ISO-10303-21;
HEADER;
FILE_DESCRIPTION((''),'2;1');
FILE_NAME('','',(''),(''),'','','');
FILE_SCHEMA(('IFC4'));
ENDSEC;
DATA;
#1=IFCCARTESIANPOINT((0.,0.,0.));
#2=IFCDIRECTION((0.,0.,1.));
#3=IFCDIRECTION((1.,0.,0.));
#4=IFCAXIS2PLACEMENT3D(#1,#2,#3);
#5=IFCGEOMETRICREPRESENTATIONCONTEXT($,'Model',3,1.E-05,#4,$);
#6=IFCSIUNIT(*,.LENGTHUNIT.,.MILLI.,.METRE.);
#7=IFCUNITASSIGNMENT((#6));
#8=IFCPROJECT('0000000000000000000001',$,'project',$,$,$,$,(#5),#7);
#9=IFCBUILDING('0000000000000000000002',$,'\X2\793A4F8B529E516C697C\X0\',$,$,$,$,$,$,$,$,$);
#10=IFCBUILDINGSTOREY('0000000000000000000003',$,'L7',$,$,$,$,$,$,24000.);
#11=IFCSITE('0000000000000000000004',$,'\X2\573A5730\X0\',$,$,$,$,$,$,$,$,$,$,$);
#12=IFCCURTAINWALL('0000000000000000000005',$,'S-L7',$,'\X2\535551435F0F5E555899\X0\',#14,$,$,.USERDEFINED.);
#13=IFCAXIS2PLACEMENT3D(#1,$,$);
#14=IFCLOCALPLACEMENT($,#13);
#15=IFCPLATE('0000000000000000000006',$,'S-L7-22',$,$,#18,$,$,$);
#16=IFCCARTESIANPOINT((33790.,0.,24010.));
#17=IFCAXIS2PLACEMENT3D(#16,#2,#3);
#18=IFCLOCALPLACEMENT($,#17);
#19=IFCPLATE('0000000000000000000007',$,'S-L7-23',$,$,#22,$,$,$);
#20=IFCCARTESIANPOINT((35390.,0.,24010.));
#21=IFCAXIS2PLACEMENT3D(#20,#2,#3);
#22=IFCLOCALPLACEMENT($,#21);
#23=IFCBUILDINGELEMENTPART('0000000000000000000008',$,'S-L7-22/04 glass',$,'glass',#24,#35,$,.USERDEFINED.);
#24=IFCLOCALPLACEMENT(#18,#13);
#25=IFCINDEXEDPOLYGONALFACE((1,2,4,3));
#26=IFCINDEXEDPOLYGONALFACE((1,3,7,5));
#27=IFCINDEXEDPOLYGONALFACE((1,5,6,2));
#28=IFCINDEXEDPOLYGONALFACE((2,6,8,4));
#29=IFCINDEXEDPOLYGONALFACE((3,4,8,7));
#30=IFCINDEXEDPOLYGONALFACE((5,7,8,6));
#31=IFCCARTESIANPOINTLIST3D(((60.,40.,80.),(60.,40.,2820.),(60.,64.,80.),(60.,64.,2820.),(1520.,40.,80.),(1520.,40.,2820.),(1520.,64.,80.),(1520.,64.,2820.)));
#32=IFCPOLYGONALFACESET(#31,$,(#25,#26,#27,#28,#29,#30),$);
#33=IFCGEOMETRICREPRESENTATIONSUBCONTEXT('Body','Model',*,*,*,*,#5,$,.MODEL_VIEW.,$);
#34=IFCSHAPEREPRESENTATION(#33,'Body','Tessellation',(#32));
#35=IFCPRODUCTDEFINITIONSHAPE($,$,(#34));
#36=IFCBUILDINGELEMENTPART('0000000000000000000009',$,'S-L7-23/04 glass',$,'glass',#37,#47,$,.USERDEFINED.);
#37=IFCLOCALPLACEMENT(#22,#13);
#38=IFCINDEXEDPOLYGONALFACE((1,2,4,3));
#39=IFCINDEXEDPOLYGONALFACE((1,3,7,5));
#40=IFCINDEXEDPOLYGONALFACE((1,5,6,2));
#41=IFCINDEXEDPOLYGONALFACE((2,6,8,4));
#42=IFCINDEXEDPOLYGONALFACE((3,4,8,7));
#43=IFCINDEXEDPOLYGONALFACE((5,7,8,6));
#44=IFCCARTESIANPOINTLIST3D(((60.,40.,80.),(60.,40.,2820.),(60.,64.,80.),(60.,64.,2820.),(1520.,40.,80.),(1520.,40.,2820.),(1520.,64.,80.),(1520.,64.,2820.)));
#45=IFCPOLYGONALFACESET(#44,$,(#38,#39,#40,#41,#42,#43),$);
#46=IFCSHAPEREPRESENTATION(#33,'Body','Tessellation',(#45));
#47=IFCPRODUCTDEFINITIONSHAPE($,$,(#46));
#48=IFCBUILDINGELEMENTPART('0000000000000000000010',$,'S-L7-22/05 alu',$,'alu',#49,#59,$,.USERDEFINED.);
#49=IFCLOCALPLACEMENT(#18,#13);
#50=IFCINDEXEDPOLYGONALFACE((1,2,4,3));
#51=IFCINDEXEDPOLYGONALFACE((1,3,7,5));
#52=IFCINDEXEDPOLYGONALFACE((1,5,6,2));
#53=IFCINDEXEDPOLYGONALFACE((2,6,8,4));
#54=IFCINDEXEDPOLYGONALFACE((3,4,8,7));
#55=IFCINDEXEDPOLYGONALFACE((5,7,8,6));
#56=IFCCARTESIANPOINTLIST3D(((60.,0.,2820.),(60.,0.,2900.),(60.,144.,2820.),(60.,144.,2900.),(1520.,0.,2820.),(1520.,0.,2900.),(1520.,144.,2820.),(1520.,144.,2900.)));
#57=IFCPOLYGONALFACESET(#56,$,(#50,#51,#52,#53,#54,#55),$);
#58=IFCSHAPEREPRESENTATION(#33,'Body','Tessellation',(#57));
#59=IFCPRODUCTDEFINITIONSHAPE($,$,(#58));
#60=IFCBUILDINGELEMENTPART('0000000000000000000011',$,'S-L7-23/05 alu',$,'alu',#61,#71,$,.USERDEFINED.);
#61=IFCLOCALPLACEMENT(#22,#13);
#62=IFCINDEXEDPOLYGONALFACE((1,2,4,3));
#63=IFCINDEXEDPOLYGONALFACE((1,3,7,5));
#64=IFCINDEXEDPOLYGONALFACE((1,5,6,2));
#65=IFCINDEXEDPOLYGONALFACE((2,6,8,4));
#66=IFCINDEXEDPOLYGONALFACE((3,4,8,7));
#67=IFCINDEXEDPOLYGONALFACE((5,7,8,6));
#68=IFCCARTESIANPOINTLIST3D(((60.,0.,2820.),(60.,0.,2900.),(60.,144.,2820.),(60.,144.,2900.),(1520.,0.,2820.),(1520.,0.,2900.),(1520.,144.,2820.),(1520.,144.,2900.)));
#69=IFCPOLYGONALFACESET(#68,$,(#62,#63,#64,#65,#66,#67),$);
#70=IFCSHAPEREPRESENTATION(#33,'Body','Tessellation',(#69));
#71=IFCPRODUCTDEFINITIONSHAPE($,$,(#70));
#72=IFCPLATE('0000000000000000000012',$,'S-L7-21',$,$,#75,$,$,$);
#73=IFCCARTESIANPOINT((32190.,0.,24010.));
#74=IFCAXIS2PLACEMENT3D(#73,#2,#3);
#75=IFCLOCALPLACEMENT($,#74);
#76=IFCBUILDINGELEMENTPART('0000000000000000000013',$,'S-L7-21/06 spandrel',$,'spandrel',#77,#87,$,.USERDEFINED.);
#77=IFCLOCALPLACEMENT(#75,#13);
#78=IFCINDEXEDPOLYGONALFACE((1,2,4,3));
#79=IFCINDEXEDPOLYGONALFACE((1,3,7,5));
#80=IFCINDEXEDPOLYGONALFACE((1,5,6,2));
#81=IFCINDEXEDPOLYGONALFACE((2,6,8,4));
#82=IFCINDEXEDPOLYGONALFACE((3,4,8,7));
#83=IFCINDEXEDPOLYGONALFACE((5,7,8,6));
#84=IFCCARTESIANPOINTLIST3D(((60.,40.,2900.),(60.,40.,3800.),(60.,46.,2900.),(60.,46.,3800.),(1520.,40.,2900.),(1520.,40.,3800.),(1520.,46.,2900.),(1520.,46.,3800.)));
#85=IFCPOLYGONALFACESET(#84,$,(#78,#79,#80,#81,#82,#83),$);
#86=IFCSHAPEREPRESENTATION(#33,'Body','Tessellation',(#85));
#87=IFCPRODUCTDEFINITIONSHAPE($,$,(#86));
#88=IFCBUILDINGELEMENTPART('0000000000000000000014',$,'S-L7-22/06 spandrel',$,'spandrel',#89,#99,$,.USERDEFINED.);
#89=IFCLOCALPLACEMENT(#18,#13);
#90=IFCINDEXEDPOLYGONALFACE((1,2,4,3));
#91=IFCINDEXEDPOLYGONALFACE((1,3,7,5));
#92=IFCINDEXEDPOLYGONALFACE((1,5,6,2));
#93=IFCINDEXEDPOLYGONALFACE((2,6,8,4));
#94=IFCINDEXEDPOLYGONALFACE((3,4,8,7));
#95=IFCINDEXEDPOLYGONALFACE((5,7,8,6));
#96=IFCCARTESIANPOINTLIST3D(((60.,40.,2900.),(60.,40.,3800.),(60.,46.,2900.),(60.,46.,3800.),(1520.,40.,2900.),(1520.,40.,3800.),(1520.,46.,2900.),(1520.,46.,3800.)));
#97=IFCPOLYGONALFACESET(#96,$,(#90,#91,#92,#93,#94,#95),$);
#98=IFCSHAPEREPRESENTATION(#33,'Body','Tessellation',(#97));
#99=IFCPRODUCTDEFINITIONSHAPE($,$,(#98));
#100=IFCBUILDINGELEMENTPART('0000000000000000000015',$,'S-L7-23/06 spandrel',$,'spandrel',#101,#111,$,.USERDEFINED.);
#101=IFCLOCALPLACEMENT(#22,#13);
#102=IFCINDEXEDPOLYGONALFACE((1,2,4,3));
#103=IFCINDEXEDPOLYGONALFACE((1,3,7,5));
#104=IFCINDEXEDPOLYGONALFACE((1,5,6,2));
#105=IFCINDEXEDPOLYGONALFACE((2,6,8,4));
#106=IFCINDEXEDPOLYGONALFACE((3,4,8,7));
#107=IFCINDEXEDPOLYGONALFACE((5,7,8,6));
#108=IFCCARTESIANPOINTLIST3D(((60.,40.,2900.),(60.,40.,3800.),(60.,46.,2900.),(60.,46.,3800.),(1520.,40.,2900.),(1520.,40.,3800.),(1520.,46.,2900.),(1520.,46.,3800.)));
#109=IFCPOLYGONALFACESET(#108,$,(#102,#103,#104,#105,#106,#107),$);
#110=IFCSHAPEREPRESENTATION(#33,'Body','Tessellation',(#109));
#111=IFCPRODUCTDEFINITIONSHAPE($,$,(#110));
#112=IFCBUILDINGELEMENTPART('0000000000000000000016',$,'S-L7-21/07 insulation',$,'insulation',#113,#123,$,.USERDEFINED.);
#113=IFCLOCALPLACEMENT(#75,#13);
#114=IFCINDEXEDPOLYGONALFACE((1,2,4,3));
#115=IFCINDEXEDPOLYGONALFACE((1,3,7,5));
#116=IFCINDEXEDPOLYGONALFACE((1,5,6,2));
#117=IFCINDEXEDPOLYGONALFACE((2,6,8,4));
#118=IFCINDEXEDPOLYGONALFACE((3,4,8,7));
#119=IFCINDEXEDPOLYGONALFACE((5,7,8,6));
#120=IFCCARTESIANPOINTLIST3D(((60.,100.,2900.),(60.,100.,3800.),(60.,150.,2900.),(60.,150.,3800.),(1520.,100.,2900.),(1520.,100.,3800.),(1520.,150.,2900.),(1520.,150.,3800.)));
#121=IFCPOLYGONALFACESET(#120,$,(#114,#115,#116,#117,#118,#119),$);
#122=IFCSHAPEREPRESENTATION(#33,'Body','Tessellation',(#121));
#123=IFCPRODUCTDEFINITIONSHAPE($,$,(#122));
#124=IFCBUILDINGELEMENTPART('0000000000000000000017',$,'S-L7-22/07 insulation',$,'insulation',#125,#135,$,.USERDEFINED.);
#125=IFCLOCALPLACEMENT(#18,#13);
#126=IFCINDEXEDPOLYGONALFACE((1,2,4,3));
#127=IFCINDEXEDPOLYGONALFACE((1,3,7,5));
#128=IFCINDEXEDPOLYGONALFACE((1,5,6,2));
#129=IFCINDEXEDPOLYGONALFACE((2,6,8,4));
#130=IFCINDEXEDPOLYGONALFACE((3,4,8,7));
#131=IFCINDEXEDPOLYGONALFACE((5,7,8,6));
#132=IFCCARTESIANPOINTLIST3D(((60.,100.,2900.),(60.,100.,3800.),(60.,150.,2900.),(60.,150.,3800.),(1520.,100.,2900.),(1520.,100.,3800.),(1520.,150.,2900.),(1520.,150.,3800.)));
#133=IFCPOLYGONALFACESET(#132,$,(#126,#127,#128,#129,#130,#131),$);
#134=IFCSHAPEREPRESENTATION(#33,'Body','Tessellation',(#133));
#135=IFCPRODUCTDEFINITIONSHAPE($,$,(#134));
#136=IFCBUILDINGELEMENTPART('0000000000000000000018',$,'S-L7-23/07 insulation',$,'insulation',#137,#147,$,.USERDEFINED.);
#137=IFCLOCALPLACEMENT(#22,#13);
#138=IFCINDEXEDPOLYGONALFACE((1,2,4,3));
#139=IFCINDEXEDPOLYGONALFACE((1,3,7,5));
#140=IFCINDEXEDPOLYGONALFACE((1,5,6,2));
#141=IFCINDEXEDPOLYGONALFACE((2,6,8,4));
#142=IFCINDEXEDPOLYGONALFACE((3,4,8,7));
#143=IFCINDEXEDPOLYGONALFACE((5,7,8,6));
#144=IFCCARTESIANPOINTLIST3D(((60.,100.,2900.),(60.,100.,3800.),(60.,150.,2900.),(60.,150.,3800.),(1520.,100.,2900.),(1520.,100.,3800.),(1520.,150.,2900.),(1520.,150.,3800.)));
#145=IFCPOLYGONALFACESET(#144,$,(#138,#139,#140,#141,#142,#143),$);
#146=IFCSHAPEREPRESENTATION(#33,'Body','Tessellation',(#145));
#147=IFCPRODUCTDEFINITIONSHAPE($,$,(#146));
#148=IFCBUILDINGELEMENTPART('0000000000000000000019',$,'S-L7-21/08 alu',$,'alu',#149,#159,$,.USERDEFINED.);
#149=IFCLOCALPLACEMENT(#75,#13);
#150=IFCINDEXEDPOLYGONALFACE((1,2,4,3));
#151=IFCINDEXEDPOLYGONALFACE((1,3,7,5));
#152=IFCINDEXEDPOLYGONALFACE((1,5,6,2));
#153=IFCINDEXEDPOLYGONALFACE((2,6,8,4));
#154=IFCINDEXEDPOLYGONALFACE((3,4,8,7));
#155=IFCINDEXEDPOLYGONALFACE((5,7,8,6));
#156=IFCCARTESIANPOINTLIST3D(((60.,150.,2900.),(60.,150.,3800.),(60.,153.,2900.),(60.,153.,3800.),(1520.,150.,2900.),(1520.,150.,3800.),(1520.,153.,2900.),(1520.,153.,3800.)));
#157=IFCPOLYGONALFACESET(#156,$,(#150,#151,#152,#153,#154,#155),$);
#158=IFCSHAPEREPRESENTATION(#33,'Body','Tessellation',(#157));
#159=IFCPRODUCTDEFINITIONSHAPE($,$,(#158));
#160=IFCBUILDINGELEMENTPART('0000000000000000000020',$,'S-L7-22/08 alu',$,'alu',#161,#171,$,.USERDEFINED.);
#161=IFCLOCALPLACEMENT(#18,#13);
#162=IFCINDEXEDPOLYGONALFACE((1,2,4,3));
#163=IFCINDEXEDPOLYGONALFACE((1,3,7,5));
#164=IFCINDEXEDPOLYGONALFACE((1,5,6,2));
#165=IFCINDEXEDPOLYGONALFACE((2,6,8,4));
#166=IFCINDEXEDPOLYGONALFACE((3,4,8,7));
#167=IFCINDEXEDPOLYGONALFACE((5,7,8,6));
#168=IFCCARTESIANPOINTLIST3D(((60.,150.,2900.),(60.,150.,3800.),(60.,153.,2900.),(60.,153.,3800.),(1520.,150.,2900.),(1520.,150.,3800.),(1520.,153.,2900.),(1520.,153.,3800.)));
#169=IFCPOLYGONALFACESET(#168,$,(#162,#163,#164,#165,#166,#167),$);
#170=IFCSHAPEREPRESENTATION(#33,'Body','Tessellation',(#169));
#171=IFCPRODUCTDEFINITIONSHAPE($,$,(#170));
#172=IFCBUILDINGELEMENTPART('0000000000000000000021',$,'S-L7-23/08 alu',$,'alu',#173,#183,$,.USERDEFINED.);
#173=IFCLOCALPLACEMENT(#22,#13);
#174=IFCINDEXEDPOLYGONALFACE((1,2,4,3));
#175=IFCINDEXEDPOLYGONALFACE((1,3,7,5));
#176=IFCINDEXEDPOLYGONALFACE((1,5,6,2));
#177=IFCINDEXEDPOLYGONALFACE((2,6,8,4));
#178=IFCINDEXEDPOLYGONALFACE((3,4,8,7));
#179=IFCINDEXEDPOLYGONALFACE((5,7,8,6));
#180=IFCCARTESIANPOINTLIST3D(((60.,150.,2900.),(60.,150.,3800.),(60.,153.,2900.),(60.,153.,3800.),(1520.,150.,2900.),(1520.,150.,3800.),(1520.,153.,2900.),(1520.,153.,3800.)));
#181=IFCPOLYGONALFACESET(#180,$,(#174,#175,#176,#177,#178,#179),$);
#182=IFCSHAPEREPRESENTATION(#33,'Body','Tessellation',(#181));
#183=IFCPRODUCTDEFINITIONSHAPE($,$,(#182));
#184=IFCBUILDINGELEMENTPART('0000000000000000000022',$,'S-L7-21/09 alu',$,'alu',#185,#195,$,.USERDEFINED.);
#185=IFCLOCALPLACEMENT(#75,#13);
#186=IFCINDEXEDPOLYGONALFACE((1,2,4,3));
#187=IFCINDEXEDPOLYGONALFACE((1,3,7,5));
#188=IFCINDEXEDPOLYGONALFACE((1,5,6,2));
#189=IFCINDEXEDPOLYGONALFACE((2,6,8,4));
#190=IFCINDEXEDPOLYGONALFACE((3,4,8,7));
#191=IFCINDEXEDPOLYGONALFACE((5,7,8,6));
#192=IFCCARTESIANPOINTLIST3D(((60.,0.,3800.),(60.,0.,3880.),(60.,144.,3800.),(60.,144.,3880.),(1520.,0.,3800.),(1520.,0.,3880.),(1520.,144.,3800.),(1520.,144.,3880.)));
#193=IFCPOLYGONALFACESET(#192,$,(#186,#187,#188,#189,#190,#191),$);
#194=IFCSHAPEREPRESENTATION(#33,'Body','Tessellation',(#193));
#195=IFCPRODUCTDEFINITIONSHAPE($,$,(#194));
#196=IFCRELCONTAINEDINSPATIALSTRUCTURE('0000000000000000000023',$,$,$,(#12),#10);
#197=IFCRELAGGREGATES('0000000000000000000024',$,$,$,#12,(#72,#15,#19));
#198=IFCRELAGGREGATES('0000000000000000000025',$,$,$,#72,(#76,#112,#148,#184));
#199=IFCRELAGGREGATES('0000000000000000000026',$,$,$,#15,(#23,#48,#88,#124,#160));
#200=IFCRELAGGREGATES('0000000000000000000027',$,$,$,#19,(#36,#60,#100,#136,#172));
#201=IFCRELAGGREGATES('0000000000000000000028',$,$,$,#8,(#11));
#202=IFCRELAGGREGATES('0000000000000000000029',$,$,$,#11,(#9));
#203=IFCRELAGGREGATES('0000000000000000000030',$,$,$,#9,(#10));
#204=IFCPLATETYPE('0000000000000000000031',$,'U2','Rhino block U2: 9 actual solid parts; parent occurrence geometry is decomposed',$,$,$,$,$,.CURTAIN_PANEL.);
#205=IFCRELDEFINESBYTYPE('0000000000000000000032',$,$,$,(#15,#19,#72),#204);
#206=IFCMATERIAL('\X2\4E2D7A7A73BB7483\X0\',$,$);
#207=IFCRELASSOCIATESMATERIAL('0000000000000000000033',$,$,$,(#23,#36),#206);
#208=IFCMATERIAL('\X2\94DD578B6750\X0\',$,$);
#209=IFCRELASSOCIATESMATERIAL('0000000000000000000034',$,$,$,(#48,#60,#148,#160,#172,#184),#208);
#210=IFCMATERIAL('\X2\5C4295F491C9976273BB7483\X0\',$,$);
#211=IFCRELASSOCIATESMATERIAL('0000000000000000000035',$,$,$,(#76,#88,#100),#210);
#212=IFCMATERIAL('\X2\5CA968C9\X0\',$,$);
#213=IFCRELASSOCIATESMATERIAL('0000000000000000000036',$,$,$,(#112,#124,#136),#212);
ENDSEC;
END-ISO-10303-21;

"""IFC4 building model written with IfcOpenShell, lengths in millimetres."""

from ifc_helpers import new_model, si_unit, frame, frame_2d, origin, origin_with_axes, place, context, subcontext, project, spatial, rectangle, extrude, source, transform, mapped, material, type_object, element, aggregate, save


model = new_model("IFC4")

# Units and contexts
model_context = context("Model", 3, precision=1e-05, world=origin_with_axes())
body_context = subcontext(model_context, "Body", "Model", "MODEL_VIEW")
ifc_project = project(units=[si_unit("LENGTHUNIT", "METRE", prefix="MILLI")], contexts=[model_context])

# Site, building, storey
site = spatial("IfcSite", under=ifc_project, Name="场地")
building = spatial("IfcBuilding", under=site, Name="示例办公楼")
storey = spatial("IfcBuildingStorey", under=building, Name="L7", Elevation=24000.0)

# Curtain wall, plates, building element parts
curtain_wall = element("IfcCurtainWall", 1, inside=storey, Name="S-L7", ObjectType="单元式幕墙", PredefinedType="USERDEFINED")
plate_type = type_object("IfcPlateType", Name="U2", Description="Rhino block U2: 9 actual solid parts; parent occurrence geometry is decomposed", PredefinedType="CURTAIN_PANEL")
plate_1_placement = place(None, frame((33790.0, 0.0, 24010.0), z_axis=(0.0, 0.0, 1.0), x_axis=(1.0, 0.0, 0.0)))
plate_1 = element("IfcPlate", 2, at=plate_1_placement, type_object=plate_type, Name="S-L7-22")
ifc_material_1 = material(Name="铝型材")
plate_2_placement = place(None, frame((35390.0, 0.0, 24010.0), z_axis=(0.0, 0.0, 1.0), x_axis=(1.0, 0.0, 0.0)))
plate_2 = element("IfcPlate", 3, at=plate_2_placement, type_object=plate_type, Name="S-L7-23")
ifc_material_2 = material(Name="中空玻璃")
shared_shape_1 = source(origin(), body_context, "Body", "SweptSolid", [
    extrude(rectangle(XDim=1460.0, YDim=24.0, at=frame_2d((790.0, 52.0))), frame((0.0, 0.0, 80.0)), (0.0, 0.0, 1.0), 2740.0),
])
building_element_part_1_placement = place(plate_1_placement, origin())
building_element_part_1 = element("IfcBuildingElementPart", 4, at=building_element_part_1_placement, material=ifc_material_2, Name="S-L7-22/04 glass", ObjectType="glass", PredefinedType="USERDEFINED", context=body_context, shape_type="MappedRepresentation", body=[
    mapped(shared_shape_1, transform((0.0, 0.0, 0.0))),
])
building_element_part_2_placement = place(plate_2_placement, origin())
building_element_part_2 = element("IfcBuildingElementPart", 5, at=building_element_part_2_placement, material=ifc_material_2, Name="S-L7-23/04 glass", ObjectType="glass", PredefinedType="USERDEFINED", context=body_context, shape_type="MappedRepresentation", body=[
    mapped(shared_shape_1, transform((0.0, 0.0, 0.0))),
])
shared_shape_2 = source(origin(), body_context, "Body", "SweptSolid", [
    extrude(rectangle(XDim=1460.0, YDim=144.0, at=frame_2d((790.0, 72.0))), frame((0.0, 0.0, 2820.0)), (0.0, 0.0, 1.0), 80.0),
])
building_element_part_3_placement = place(plate_1_placement, origin())
building_element_part_3 = element("IfcBuildingElementPart", 6, at=building_element_part_3_placement, material=ifc_material_1, Name="S-L7-22/05 alu", ObjectType="alu", PredefinedType="USERDEFINED", context=body_context, shape_type="MappedRepresentation", body=[
    mapped(shared_shape_2, transform((0.0, 0.0, 0.0))),
])
building_element_part_4_placement = place(plate_2_placement, origin())
building_element_part_4 = element("IfcBuildingElementPart", 7, at=building_element_part_4_placement, material=ifc_material_1, Name="S-L7-23/05 alu", ObjectType="alu", PredefinedType="USERDEFINED", context=body_context, shape_type="MappedRepresentation", body=[
    mapped(shared_shape_2, transform((0.0, 0.0, 0.0))),
])
plate_3_placement = place(None, frame((32190.0, 0.0, 24010.0), z_axis=(0.0, 0.0, 1.0), x_axis=(1.0, 0.0, 0.0)))
plate_3 = element("IfcPlate", 8, at=plate_3_placement, type_object=plate_type, Name="S-L7-21")
aggregate(curtain_wall, [plate_3, plate_1, plate_2])
ifc_material_3 = material(Name="层间釉面玻璃")
shared_shape_3 = source(origin(), body_context, "Body", "SweptSolid", [
    extrude(rectangle(XDim=1460.0, YDim=6.0, at=frame_2d((790.0, 43.0))), frame((0.0, 0.0, 2900.0)), (0.0, 0.0, 1.0), 900.0),
])
building_element_part_5_placement = place(plate_3_placement, origin())
building_element_part_5 = element("IfcBuildingElementPart", 9, at=building_element_part_5_placement, material=ifc_material_3, Name="S-L7-21/06 spandrel", ObjectType="spandrel", PredefinedType="USERDEFINED", context=body_context, shape_type="MappedRepresentation", body=[
    mapped(shared_shape_3, transform((0.0, 0.0, 0.0))),
])
building_element_part_6_placement = place(plate_1_placement, origin())
building_element_part_6 = element("IfcBuildingElementPart", 10, at=building_element_part_6_placement, material=ifc_material_3, Name="S-L7-22/06 spandrel", ObjectType="spandrel", PredefinedType="USERDEFINED", context=body_context, shape_type="MappedRepresentation", body=[
    mapped(shared_shape_3, transform((0.0, 0.0, 0.0))),
])
building_element_part_7_placement = place(plate_2_placement, origin())
building_element_part_7 = element("IfcBuildingElementPart", 11, at=building_element_part_7_placement, material=ifc_material_3, Name="S-L7-23/06 spandrel", ObjectType="spandrel", PredefinedType="USERDEFINED", context=body_context, shape_type="MappedRepresentation", body=[
    mapped(shared_shape_3, transform((0.0, 0.0, 0.0))),
])
ifc_material_4 = material(Name="岩棉")
shared_shape_4 = source(origin(), body_context, "Body", "SweptSolid", [
    extrude(rectangle(XDim=1460.0, YDim=50.0, at=frame_2d((790.0, 125.0))), frame((0.0, 0.0, 2900.0)), (0.0, 0.0, 1.0), 900.0),
])
building_element_part_8_placement = place(plate_3_placement, origin())
building_element_part_8 = element("IfcBuildingElementPart", 12, at=building_element_part_8_placement, material=ifc_material_4, Name="S-L7-21/07 insulation", ObjectType="insulation", PredefinedType="USERDEFINED", context=body_context, shape_type="MappedRepresentation", body=[
    mapped(shared_shape_4, transform((0.0, 0.0, 0.0))),
])
building_element_part_9_placement = place(plate_1_placement, origin())
building_element_part_9 = element("IfcBuildingElementPart", 13, at=building_element_part_9_placement, material=ifc_material_4, Name="S-L7-22/07 insulation", ObjectType="insulation", PredefinedType="USERDEFINED", context=body_context, shape_type="MappedRepresentation", body=[
    mapped(shared_shape_4, transform((0.0, 0.0, 0.0))),
])
building_element_part_10_placement = place(plate_2_placement, origin())
building_element_part_10 = element("IfcBuildingElementPart", 14, at=building_element_part_10_placement, material=ifc_material_4, Name="S-L7-23/07 insulation", ObjectType="insulation", PredefinedType="USERDEFINED", context=body_context, shape_type="MappedRepresentation", body=[
    mapped(shared_shape_4, transform((0.0, 0.0, 0.0))),
])
shared_shape_5 = source(origin(), body_context, "Body", "SweptSolid", [
    extrude(rectangle(XDim=1460.0, YDim=3.0, at=frame_2d((790.0, 151.5))), frame((0.0, 0.0, 2900.0)), (0.0, 0.0, 1.0), 900.0),
])
building_element_part_11_placement = place(plate_3_placement, origin())
building_element_part_11 = element("IfcBuildingElementPart", 15, at=building_element_part_11_placement, material=ifc_material_1, Name="S-L7-21/08 alu", ObjectType="alu", PredefinedType="USERDEFINED", context=body_context, shape_type="MappedRepresentation", body=[
    mapped(shared_shape_5, transform((0.0, 0.0, 0.0))),
])
building_element_part_12_placement = place(plate_1_placement, origin())
building_element_part_12 = element("IfcBuildingElementPart", 16, at=building_element_part_12_placement, material=ifc_material_1, Name="S-L7-22/08 alu", ObjectType="alu", PredefinedType="USERDEFINED", context=body_context, shape_type="MappedRepresentation", body=[
    mapped(shared_shape_5, transform((0.0, 0.0, 0.0))),
])
building_element_part_13_placement = place(plate_2_placement, origin())
building_element_part_13 = element("IfcBuildingElementPart", 17, at=building_element_part_13_placement, material=ifc_material_1, Name="S-L7-23/08 alu", ObjectType="alu", PredefinedType="USERDEFINED", context=body_context, shape_type="MappedRepresentation", body=[
    mapped(shared_shape_5, transform((0.0, 0.0, 0.0))),
])
shared_shape_6 = source(origin(), body_context, "Body", "SweptSolid", [
    extrude(rectangle(XDim=1460.0, YDim=144.0, at=frame_2d((790.0, 72.0))), frame((0.0, 0.0, 3800.0)), (0.0, 0.0, 1.0), 80.0),
])
building_element_part_14_placement = place(plate_3_placement, origin())
building_element_part_14 = element("IfcBuildingElementPart", 18, at=building_element_part_14_placement, material=ifc_material_1, Name="S-L7-21/09 alu", ObjectType="alu", PredefinedType="USERDEFINED", context=body_context, shape_type="MappedRepresentation", body=[
    mapped(shared_shape_6, transform((0.0, 0.0, 0.0))),
])
aggregate(plate_3, [building_element_part_5, building_element_part_8, building_element_part_11, building_element_part_14])
aggregate(plate_1, [building_element_part_1, building_element_part_3, building_element_part_6, building_element_part_9, building_element_part_12])
aggregate(plate_2, [building_element_part_2, building_element_part_4, building_element_part_7, building_element_part_10, building_element_part_13])

save(model, "model.ifc")
